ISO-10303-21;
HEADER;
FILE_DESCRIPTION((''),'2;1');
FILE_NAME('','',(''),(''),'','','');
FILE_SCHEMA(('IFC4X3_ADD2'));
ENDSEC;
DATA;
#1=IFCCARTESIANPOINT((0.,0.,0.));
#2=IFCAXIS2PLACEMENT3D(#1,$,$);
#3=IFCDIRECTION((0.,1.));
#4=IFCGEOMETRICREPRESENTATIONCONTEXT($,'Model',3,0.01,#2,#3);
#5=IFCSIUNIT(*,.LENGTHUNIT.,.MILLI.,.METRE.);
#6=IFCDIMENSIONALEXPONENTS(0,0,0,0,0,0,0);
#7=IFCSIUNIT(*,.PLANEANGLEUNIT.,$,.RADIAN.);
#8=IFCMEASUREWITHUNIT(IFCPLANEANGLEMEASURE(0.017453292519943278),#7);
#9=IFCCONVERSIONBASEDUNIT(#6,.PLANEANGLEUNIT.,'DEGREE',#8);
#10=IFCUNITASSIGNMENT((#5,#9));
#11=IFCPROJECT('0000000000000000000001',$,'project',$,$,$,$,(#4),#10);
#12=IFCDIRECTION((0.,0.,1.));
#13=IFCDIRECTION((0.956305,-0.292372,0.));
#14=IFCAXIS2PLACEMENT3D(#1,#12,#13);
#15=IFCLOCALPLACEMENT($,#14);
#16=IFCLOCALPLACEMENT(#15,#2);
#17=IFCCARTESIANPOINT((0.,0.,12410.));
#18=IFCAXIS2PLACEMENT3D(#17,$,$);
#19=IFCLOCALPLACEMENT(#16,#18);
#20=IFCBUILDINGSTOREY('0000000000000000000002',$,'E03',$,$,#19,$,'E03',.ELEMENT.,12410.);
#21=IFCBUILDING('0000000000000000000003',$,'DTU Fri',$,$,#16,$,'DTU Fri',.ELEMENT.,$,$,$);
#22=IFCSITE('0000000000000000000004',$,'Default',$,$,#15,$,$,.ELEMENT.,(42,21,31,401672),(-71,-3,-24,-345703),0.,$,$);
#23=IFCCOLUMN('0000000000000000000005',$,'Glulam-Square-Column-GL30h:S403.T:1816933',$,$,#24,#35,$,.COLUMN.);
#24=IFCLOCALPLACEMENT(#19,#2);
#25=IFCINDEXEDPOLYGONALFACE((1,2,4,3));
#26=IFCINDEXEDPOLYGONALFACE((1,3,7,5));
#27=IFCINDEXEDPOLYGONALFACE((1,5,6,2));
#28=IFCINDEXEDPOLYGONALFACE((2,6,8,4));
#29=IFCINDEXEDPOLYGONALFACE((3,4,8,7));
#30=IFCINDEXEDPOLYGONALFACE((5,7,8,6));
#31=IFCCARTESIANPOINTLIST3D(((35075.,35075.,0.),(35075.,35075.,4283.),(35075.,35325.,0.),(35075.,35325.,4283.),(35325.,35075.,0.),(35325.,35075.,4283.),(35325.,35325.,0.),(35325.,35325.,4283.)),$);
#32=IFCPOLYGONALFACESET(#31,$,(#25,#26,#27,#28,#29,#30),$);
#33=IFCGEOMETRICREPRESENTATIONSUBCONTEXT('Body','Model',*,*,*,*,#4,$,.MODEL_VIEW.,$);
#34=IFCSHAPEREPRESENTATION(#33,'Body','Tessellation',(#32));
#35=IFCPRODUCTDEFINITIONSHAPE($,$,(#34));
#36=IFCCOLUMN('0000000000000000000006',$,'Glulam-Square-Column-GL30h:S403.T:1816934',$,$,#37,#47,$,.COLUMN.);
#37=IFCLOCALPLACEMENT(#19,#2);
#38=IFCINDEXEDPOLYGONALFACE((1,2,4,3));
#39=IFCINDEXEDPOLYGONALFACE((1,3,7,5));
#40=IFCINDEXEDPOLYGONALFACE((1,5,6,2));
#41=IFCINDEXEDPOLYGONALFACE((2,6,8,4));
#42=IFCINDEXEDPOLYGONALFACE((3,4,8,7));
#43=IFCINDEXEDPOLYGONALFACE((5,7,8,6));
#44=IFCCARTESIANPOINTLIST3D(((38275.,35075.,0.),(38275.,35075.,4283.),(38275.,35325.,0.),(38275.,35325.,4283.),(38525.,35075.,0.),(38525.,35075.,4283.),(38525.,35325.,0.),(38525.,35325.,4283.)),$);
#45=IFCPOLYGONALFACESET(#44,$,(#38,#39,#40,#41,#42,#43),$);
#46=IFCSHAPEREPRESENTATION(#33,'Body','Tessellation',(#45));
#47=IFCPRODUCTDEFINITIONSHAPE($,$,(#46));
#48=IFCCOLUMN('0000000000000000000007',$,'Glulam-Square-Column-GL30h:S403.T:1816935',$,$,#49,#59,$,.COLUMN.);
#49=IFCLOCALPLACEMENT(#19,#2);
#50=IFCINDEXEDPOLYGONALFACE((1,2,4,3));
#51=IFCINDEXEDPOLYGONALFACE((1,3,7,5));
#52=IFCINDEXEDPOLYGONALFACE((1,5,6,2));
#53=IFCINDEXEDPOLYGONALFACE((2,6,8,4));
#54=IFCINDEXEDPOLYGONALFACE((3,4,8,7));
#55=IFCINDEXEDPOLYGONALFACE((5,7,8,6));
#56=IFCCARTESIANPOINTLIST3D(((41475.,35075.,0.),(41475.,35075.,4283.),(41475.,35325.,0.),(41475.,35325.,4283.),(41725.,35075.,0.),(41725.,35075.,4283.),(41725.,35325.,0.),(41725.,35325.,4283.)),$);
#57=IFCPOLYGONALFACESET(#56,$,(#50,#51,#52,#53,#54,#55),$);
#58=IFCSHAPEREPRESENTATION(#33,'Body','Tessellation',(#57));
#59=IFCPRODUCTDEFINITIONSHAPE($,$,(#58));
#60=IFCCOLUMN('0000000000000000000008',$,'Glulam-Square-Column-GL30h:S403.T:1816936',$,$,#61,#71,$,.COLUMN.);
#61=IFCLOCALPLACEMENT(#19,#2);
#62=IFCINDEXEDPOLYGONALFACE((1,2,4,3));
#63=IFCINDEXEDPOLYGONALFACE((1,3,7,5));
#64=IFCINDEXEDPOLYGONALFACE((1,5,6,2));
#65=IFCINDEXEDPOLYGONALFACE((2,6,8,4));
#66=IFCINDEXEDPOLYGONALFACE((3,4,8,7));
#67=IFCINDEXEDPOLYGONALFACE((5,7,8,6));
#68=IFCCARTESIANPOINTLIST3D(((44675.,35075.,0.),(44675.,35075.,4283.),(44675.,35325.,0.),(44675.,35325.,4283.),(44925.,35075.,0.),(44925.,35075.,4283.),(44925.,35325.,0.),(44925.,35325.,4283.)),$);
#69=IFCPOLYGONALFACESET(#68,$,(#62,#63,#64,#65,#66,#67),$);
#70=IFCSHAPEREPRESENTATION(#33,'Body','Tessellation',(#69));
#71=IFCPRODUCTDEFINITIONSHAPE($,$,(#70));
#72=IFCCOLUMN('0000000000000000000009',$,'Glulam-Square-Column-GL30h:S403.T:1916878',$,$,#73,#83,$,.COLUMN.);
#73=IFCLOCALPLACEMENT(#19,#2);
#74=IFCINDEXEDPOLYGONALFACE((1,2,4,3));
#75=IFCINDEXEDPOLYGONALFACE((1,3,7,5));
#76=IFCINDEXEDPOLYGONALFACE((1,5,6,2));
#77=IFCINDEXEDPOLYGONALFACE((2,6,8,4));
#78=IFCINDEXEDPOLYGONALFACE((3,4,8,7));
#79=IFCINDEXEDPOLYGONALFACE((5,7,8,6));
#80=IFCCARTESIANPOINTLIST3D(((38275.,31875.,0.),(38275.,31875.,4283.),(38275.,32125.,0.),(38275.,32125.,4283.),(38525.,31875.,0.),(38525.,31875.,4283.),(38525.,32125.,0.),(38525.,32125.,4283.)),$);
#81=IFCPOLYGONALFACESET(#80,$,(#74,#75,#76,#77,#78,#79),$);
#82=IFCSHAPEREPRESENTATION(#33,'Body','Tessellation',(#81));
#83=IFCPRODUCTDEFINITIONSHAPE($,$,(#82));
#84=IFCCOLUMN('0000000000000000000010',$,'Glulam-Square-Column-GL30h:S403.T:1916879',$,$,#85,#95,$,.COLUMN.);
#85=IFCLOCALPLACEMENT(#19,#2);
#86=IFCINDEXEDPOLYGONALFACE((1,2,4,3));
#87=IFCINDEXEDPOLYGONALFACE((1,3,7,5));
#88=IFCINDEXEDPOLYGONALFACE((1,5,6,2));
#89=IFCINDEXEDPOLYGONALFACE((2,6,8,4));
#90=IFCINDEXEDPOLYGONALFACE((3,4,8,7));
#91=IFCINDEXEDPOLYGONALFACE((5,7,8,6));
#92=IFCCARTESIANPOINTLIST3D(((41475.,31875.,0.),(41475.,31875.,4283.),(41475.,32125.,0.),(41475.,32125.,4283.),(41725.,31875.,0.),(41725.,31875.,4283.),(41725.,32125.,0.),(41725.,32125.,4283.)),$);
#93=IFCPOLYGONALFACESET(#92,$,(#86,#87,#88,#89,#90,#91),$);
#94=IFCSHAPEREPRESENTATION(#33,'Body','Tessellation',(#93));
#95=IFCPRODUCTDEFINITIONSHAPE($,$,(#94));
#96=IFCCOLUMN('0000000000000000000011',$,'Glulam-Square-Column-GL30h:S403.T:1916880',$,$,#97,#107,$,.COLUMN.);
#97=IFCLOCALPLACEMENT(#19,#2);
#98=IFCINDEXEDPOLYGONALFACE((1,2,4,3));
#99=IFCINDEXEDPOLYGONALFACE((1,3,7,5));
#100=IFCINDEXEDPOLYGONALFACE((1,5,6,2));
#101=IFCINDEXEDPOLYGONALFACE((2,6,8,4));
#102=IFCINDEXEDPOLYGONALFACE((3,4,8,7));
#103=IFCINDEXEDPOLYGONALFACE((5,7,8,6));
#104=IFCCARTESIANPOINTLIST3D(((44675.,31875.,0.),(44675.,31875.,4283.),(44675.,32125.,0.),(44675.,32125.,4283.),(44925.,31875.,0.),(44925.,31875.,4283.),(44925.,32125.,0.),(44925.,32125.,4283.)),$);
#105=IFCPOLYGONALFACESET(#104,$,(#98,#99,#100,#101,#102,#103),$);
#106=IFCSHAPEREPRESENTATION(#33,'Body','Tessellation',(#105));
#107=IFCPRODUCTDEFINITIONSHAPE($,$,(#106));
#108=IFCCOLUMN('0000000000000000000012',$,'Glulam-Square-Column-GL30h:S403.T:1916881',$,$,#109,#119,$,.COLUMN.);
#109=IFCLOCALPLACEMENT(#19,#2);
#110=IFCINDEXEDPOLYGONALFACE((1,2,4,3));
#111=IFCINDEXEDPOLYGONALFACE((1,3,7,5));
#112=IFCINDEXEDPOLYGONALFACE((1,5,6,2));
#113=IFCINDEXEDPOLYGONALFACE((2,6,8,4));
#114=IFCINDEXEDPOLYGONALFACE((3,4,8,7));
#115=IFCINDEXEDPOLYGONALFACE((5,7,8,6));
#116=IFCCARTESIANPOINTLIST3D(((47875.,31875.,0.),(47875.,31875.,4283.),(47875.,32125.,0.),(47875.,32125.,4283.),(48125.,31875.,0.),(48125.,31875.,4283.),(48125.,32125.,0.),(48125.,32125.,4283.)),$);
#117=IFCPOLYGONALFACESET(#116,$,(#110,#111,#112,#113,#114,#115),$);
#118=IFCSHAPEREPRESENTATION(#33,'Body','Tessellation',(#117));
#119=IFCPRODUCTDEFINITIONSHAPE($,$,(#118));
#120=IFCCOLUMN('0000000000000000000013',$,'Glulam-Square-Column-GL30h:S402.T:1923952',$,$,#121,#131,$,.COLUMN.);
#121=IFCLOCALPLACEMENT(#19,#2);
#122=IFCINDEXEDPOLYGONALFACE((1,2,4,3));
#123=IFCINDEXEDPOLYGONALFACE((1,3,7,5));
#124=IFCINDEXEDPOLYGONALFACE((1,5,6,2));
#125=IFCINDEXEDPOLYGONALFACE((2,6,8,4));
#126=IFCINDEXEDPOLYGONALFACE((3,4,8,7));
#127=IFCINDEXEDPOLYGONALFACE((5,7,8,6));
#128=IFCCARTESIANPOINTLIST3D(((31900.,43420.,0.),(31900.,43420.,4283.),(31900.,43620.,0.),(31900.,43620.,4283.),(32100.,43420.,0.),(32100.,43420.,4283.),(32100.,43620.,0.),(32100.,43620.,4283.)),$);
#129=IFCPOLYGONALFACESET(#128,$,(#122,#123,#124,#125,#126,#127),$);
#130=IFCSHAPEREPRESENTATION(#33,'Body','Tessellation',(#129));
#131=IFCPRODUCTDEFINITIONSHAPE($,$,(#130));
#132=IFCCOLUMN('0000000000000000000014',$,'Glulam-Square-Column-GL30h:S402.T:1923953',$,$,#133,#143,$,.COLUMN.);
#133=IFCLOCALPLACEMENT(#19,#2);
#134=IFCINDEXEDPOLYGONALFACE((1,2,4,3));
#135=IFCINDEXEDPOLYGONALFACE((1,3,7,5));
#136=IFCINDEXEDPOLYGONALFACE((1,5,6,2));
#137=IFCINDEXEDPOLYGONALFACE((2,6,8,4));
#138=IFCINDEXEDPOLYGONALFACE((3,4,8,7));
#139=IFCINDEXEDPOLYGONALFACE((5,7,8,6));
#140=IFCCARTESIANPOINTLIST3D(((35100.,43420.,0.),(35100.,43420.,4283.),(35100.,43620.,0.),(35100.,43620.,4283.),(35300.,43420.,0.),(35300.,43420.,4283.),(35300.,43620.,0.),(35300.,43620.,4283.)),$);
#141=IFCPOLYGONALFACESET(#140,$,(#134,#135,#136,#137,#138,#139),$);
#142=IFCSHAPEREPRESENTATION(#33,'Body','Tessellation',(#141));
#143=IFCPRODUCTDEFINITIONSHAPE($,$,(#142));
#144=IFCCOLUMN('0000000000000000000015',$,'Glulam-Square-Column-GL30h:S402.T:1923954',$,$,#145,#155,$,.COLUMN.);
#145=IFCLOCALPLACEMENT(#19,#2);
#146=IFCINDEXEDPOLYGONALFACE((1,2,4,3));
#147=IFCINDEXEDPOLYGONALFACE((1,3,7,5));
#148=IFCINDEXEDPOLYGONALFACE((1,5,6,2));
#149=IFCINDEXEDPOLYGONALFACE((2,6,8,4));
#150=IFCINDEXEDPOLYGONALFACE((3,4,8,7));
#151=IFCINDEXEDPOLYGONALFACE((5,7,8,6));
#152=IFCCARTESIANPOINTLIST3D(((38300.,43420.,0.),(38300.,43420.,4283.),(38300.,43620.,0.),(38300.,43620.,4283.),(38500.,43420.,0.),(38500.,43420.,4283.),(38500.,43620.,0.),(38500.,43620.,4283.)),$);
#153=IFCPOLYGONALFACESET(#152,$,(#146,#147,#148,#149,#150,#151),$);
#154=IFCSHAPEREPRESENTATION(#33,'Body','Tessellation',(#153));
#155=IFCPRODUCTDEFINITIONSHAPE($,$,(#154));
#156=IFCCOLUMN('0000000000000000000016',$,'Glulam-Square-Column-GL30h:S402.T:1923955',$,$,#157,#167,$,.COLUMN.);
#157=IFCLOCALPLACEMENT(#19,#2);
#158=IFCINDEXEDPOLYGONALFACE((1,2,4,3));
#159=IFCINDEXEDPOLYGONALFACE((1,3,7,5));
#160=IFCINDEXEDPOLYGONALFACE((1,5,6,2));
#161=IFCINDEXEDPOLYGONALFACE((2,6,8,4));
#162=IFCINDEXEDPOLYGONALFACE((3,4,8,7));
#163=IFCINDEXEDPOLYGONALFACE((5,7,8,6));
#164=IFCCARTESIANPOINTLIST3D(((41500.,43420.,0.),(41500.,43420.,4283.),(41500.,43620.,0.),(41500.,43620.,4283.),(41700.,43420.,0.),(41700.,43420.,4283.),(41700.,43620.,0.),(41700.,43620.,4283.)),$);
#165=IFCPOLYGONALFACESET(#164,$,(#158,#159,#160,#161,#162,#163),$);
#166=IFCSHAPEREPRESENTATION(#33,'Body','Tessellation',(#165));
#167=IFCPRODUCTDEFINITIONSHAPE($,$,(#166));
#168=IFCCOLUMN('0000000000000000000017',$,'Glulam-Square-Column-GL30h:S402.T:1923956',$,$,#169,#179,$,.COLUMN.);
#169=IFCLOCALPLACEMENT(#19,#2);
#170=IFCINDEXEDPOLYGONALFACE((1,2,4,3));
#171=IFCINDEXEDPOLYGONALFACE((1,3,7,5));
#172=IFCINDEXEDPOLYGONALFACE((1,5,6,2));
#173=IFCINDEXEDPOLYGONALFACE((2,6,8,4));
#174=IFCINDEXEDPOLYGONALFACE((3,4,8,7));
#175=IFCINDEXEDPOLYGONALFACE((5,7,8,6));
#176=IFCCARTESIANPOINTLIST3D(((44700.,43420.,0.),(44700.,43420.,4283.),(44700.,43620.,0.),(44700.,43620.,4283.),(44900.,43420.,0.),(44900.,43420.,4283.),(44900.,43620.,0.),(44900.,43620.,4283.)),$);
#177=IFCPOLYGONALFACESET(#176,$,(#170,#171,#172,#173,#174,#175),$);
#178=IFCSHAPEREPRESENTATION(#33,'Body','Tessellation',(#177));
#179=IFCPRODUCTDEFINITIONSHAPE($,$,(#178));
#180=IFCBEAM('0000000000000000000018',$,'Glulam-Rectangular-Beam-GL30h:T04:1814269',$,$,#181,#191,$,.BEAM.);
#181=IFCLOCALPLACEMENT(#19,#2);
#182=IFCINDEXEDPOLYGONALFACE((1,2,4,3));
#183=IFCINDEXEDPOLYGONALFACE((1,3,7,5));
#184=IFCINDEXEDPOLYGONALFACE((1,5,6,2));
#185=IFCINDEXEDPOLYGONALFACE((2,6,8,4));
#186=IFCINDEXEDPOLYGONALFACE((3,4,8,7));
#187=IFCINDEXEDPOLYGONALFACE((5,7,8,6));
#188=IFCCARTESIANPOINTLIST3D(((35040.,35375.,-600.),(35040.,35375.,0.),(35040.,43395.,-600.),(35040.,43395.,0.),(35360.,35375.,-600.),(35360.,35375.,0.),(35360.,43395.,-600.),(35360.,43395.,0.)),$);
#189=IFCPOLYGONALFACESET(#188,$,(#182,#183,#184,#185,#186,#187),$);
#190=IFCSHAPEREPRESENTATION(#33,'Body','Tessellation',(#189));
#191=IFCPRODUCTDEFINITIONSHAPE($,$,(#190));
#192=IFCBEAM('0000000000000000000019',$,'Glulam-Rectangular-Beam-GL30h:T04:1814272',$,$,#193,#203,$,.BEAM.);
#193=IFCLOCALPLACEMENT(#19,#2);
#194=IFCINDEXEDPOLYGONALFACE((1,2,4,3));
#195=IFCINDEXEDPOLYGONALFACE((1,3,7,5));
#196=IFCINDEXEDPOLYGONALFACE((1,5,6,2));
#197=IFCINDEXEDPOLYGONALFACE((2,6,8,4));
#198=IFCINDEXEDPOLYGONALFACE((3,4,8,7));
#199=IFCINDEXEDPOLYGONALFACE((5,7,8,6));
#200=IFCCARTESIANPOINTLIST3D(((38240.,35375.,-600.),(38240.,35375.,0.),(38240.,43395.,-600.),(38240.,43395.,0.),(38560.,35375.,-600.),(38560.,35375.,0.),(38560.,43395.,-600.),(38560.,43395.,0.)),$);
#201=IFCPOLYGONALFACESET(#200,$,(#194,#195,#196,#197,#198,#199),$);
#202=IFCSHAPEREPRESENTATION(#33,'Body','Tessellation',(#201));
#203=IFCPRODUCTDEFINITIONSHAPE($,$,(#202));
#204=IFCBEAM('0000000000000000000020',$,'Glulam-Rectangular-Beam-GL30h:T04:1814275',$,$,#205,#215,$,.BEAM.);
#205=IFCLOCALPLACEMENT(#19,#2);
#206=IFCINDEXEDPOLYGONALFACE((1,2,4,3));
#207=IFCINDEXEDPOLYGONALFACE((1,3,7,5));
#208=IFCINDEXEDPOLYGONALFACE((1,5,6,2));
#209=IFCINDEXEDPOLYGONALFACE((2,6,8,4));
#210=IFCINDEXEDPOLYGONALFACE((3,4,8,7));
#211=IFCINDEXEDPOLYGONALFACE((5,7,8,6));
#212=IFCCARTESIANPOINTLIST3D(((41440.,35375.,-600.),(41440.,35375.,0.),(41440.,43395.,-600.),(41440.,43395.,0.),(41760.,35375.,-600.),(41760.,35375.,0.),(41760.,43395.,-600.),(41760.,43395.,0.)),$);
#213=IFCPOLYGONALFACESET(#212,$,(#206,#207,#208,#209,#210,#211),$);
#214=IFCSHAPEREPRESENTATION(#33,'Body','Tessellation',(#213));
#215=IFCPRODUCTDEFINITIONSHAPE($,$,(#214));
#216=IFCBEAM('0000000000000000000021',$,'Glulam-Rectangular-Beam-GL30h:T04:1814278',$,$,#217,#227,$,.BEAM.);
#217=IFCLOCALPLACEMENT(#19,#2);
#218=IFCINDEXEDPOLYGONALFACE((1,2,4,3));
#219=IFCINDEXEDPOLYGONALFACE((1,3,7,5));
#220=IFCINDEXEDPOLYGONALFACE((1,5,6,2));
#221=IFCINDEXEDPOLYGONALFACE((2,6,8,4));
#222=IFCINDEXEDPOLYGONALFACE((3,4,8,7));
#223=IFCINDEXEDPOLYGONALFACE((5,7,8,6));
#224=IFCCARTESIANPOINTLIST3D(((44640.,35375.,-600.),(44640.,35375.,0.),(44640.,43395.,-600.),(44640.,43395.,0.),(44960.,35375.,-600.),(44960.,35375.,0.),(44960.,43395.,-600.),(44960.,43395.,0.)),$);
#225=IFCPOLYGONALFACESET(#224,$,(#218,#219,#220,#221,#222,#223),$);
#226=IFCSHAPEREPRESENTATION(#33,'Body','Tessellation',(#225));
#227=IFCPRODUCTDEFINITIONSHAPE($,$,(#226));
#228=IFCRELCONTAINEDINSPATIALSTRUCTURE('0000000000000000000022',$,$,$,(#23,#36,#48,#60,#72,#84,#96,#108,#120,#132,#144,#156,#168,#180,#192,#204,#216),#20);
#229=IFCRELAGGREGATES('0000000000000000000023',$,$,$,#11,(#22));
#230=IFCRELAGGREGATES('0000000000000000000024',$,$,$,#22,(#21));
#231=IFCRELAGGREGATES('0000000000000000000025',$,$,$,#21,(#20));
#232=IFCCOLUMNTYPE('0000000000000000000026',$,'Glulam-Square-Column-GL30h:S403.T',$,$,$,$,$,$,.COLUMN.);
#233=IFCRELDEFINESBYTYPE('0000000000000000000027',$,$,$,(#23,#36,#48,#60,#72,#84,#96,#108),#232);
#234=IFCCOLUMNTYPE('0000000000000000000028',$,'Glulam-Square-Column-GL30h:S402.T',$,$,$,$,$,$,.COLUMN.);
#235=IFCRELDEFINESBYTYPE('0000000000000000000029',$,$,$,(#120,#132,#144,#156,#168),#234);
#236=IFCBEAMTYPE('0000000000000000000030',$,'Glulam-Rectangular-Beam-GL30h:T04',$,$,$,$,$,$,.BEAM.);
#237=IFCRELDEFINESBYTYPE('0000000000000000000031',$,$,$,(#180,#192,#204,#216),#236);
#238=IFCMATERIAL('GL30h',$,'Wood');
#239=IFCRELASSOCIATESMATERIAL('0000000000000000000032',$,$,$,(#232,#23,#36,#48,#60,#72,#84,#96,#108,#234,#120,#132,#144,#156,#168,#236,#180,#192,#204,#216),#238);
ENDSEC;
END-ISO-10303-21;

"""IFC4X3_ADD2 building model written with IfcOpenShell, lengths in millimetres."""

from ifc_helpers import new_model, entity, si_unit, converted_unit, direction, frame, origin, origin_2d_with_axis, place, context, subcontext, project, spatial, rectangle, extrude, source, transform, mapped, material, material_profile, profile_set, profile_usage, type_object, type_shapes, element, save


model = new_model("IFC4X3_ADD2")

# Units and contexts
model_context = context("Model", 3, precision=0.01, world=origin(), true_north=direction((0.0, 1.0)))
body_context = subcontext(model_context, "Body", "Model", "MODEL_VIEW")
ifc_project = project(units=[si_unit("LENGTHUNIT", "METRE", prefix="MILLI"), converted_unit("PLANEANGLEUNIT", "DEGREE", entity("IfcPlaneAngleMeasure", 0.017453292519943278), si_unit("PLANEANGLEUNIT", "RADIAN"), dimensions=[0, 0, 0, 0, 0, 0, 0])], contexts=[model_context])

# Site, building, storey
site_placement = place(None, frame((0.0, 0.0, 0.0), z_axis=(0.0, 0.0, 1.0), x_axis=(0.956305, -0.292372, 0.0)))
site = spatial("IfcSite", under=ifc_project, at=site_placement, Name="Default", CompositionType="ELEMENT", RefLatitude=(42, 21, 31, 401672), RefLongitude=(-71, -3, -24, -345703), RefElevation=0.0)
building_placement = place(site_placement, origin())
building = spatial("IfcBuilding", under=site, at=building_placement, Name="DTU Fri", LongName="DTU Fri", CompositionType="ELEMENT")
storey_placement = place(building_placement, frame((0.0, 0.0, 12410.0)))
storey = spatial("IfcBuildingStorey", under=building, at=storey_placement, Name="E03", LongName="E03", CompositionType="ELEMENT", Elevation=12410.0)

# Columns
ifc_material = material(Name="GL30h", Category="Wood")
ifc_material_profile_1 = material_profile(ifc_material, rectangle(XDim=250.0, YDim=250.0, at=origin_2d_with_axis()), Name="S403.T")
ifc_profile_set_1 = profile_set([ifc_material_profile_1], Name="S403.T")
ifc_profile_usage_1 = profile_usage(ifc_profile_set_1)
column_type_1 = type_object("IfcColumnType", Name="Glulam-Square-Column-GL30h:S403.T", PredefinedType="COLUMN", material=ifc_profile_set_1)
shared_shape_1 = source(origin(), body_context, "Body", "SweptSolid", [
    extrude(rectangle(XDim=250.0, YDim=250.0, at=origin_2d_with_axis()), frame((0.0, 0.0, 12410.0), z_axis=(0.0, 0.0, 1.0), x_axis=(0.0, 1.0, 0.0)), (0.0, 0.0, 1.0), 4283.0),
])
type_shapes(column_type_1, [shared_shape_1])
for number, where, name in (
    (1, (35200.0, 35200.0, -12410.0), "Glulam-Square-Column-GL30h:S403.T:1816933"),
    (2, (38400.0, 35200.0, -12410.0), "Glulam-Square-Column-GL30h:S403.T:1816934"),
    (3, (41600.0, 35200.0, -12410.0), "Glulam-Square-Column-GL30h:S403.T:1816935"),
    (4, (44800.0, 35200.0, -12410.0), "Glulam-Square-Column-GL30h:S403.T:1816936"),
    (5, (38400.0, 32000.0, -12410.0), "Glulam-Square-Column-GL30h:S403.T:1916878"),
    (6, (41600.0, 32000.0, -12410.0), "Glulam-Square-Column-GL30h:S403.T:1916879"),
    (7, (44800.0, 32000.0, -12410.0), "Glulam-Square-Column-GL30h:S403.T:1916880"),
    (8, (48000.0, 32000.0, -12410.0), "Glulam-Square-Column-GL30h:S403.T:1916881"),
):
    element("IfcColumn", number, at=place(storey_placement, frame(where)), inside=storey, type_object=column_type_1, material=ifc_profile_usage_1, Name=name, PredefinedType="COLUMN", context=body_context, shape_type="MappedRepresentation", body=[
        mapped(shared_shape_1, transform((0.0, 0.0, 0.0), scale=1.0)),
    ])
ifc_material_profile_2 = material_profile(ifc_material, rectangle(XDim=200.0, YDim=200.0, at=origin_2d_with_axis()), Name="S402.T")
ifc_profile_set_2 = profile_set([ifc_material_profile_2], Name="S402.T")
ifc_profile_usage_2 = profile_usage(ifc_profile_set_2)
column_type_2 = type_object("IfcColumnType", Name="Glulam-Square-Column-GL30h:S402.T", PredefinedType="COLUMN", material=ifc_profile_set_2)
shared_shape_2 = source(origin(), body_context, "Body", "SweptSolid", [
    extrude(rectangle(XDim=200.0, YDim=200.0, at=origin_2d_with_axis()), frame((0.0, 0.0, 12410.0), z_axis=(0.0, 0.0, 1.0), x_axis=(0.0, 1.0, 0.0)), (0.0, 0.0, 1.0), 4283.0),
])
type_shapes(column_type_2, [shared_shape_2])
for number, where, name in (
    (9, (32000.0, 43520.0, -12410.0), "Glulam-Square-Column-GL30h:S402.T:1923952"),
    (10, (35200.0, 43520.0, -12410.0), "Glulam-Square-Column-GL30h:S402.T:1923953"),
    (11, (38400.0, 43520.0, -12410.0), "Glulam-Square-Column-GL30h:S402.T:1923954"),
    (12, (41600.0, 43520.0, -12410.0), "Glulam-Square-Column-GL30h:S402.T:1923955"),
    (13, (44800.0, 43520.0, -12410.0), "Glulam-Square-Column-GL30h:S402.T:1923956"),
):
    element("IfcColumn", number, at=place(storey_placement, frame(where)), inside=storey, type_object=column_type_2, material=ifc_profile_usage_2, Name=name, PredefinedType="COLUMN", context=body_context, shape_type="MappedRepresentation", body=[
        mapped(shared_shape_2, transform((0.0, 0.0, 0.0), scale=1.0)),
    ])

# Beams
ifc_material_profile_3 = material_profile(ifc_material, rectangle(XDim=600.0, YDim=320.0, at=origin_2d_with_axis()), Name="T04")
ifc_profile_set_3 = profile_set([ifc_material_profile_3], Name="T04")
ifc_profile_usage_3 = profile_usage(ifc_profile_set_3, cardinal=8)
beam_type_1 = type_object("IfcBeamType", Name="Glulam-Rectangular-Beam-GL30h:T04", PredefinedType="BEAM", material=ifc_profile_set_3)
shared_shape_3 = source(origin(), body_context, "Body", "SweptSolid", [
    extrude(rectangle(XDim=600.0, YDim=320.0, at=origin_2d_with_axis()), frame((-4035.0, 0.0, 0.0), z_axis=(1.0, 0.0, 0.0), x_axis=(0.0, 0.0, -1.0)), (0.0, 0.0, 1.0), 8020.0),
])
type_shapes(beam_type_1, [shared_shape_3])
for number, where, z_axis, x_axis, name in (
    (14, (35200.0, 39360.0, -300.0), (0.0, 0.0, 1.0), (0.0, -1.0, 0.0), "Glulam-Rectangular-Beam-GL30h:T04:1814269"),
    (15, (38400.0, 39360.0, -300.0), (0.0, 0.0, 1.0), (0.0, -1.0, 0.0), "Glulam-Rectangular-Beam-GL30h:T04:1814272"),
    (16, (41600.0, 39360.0, -300.0), (0.0, 0.0, 1.0), (0.0, -1.0, 0.0), "Glulam-Rectangular-Beam-GL30h:T04:1814275"),
    (17, (44800.0, 39360.0, -300.0), (0.0, 0.0, 1.0), (0.0, -1.0, 0.0), "Glulam-Rectangular-Beam-GL30h:T04:1814278"),
):
    element("IfcBeam", number, at=place(storey_placement, frame(where, z_axis=z_axis, x_axis=x_axis)), inside=storey, type_object=beam_type_1, material=ifc_profile_usage_3, Name=name, PredefinedType="BEAM", context=body_context, shape_type="MappedRepresentation", body=[
        mapped(shared_shape_3, transform((0.0, 0.0, 0.0), scale=1.0)),
    ])

save(model, "model.ifc")
